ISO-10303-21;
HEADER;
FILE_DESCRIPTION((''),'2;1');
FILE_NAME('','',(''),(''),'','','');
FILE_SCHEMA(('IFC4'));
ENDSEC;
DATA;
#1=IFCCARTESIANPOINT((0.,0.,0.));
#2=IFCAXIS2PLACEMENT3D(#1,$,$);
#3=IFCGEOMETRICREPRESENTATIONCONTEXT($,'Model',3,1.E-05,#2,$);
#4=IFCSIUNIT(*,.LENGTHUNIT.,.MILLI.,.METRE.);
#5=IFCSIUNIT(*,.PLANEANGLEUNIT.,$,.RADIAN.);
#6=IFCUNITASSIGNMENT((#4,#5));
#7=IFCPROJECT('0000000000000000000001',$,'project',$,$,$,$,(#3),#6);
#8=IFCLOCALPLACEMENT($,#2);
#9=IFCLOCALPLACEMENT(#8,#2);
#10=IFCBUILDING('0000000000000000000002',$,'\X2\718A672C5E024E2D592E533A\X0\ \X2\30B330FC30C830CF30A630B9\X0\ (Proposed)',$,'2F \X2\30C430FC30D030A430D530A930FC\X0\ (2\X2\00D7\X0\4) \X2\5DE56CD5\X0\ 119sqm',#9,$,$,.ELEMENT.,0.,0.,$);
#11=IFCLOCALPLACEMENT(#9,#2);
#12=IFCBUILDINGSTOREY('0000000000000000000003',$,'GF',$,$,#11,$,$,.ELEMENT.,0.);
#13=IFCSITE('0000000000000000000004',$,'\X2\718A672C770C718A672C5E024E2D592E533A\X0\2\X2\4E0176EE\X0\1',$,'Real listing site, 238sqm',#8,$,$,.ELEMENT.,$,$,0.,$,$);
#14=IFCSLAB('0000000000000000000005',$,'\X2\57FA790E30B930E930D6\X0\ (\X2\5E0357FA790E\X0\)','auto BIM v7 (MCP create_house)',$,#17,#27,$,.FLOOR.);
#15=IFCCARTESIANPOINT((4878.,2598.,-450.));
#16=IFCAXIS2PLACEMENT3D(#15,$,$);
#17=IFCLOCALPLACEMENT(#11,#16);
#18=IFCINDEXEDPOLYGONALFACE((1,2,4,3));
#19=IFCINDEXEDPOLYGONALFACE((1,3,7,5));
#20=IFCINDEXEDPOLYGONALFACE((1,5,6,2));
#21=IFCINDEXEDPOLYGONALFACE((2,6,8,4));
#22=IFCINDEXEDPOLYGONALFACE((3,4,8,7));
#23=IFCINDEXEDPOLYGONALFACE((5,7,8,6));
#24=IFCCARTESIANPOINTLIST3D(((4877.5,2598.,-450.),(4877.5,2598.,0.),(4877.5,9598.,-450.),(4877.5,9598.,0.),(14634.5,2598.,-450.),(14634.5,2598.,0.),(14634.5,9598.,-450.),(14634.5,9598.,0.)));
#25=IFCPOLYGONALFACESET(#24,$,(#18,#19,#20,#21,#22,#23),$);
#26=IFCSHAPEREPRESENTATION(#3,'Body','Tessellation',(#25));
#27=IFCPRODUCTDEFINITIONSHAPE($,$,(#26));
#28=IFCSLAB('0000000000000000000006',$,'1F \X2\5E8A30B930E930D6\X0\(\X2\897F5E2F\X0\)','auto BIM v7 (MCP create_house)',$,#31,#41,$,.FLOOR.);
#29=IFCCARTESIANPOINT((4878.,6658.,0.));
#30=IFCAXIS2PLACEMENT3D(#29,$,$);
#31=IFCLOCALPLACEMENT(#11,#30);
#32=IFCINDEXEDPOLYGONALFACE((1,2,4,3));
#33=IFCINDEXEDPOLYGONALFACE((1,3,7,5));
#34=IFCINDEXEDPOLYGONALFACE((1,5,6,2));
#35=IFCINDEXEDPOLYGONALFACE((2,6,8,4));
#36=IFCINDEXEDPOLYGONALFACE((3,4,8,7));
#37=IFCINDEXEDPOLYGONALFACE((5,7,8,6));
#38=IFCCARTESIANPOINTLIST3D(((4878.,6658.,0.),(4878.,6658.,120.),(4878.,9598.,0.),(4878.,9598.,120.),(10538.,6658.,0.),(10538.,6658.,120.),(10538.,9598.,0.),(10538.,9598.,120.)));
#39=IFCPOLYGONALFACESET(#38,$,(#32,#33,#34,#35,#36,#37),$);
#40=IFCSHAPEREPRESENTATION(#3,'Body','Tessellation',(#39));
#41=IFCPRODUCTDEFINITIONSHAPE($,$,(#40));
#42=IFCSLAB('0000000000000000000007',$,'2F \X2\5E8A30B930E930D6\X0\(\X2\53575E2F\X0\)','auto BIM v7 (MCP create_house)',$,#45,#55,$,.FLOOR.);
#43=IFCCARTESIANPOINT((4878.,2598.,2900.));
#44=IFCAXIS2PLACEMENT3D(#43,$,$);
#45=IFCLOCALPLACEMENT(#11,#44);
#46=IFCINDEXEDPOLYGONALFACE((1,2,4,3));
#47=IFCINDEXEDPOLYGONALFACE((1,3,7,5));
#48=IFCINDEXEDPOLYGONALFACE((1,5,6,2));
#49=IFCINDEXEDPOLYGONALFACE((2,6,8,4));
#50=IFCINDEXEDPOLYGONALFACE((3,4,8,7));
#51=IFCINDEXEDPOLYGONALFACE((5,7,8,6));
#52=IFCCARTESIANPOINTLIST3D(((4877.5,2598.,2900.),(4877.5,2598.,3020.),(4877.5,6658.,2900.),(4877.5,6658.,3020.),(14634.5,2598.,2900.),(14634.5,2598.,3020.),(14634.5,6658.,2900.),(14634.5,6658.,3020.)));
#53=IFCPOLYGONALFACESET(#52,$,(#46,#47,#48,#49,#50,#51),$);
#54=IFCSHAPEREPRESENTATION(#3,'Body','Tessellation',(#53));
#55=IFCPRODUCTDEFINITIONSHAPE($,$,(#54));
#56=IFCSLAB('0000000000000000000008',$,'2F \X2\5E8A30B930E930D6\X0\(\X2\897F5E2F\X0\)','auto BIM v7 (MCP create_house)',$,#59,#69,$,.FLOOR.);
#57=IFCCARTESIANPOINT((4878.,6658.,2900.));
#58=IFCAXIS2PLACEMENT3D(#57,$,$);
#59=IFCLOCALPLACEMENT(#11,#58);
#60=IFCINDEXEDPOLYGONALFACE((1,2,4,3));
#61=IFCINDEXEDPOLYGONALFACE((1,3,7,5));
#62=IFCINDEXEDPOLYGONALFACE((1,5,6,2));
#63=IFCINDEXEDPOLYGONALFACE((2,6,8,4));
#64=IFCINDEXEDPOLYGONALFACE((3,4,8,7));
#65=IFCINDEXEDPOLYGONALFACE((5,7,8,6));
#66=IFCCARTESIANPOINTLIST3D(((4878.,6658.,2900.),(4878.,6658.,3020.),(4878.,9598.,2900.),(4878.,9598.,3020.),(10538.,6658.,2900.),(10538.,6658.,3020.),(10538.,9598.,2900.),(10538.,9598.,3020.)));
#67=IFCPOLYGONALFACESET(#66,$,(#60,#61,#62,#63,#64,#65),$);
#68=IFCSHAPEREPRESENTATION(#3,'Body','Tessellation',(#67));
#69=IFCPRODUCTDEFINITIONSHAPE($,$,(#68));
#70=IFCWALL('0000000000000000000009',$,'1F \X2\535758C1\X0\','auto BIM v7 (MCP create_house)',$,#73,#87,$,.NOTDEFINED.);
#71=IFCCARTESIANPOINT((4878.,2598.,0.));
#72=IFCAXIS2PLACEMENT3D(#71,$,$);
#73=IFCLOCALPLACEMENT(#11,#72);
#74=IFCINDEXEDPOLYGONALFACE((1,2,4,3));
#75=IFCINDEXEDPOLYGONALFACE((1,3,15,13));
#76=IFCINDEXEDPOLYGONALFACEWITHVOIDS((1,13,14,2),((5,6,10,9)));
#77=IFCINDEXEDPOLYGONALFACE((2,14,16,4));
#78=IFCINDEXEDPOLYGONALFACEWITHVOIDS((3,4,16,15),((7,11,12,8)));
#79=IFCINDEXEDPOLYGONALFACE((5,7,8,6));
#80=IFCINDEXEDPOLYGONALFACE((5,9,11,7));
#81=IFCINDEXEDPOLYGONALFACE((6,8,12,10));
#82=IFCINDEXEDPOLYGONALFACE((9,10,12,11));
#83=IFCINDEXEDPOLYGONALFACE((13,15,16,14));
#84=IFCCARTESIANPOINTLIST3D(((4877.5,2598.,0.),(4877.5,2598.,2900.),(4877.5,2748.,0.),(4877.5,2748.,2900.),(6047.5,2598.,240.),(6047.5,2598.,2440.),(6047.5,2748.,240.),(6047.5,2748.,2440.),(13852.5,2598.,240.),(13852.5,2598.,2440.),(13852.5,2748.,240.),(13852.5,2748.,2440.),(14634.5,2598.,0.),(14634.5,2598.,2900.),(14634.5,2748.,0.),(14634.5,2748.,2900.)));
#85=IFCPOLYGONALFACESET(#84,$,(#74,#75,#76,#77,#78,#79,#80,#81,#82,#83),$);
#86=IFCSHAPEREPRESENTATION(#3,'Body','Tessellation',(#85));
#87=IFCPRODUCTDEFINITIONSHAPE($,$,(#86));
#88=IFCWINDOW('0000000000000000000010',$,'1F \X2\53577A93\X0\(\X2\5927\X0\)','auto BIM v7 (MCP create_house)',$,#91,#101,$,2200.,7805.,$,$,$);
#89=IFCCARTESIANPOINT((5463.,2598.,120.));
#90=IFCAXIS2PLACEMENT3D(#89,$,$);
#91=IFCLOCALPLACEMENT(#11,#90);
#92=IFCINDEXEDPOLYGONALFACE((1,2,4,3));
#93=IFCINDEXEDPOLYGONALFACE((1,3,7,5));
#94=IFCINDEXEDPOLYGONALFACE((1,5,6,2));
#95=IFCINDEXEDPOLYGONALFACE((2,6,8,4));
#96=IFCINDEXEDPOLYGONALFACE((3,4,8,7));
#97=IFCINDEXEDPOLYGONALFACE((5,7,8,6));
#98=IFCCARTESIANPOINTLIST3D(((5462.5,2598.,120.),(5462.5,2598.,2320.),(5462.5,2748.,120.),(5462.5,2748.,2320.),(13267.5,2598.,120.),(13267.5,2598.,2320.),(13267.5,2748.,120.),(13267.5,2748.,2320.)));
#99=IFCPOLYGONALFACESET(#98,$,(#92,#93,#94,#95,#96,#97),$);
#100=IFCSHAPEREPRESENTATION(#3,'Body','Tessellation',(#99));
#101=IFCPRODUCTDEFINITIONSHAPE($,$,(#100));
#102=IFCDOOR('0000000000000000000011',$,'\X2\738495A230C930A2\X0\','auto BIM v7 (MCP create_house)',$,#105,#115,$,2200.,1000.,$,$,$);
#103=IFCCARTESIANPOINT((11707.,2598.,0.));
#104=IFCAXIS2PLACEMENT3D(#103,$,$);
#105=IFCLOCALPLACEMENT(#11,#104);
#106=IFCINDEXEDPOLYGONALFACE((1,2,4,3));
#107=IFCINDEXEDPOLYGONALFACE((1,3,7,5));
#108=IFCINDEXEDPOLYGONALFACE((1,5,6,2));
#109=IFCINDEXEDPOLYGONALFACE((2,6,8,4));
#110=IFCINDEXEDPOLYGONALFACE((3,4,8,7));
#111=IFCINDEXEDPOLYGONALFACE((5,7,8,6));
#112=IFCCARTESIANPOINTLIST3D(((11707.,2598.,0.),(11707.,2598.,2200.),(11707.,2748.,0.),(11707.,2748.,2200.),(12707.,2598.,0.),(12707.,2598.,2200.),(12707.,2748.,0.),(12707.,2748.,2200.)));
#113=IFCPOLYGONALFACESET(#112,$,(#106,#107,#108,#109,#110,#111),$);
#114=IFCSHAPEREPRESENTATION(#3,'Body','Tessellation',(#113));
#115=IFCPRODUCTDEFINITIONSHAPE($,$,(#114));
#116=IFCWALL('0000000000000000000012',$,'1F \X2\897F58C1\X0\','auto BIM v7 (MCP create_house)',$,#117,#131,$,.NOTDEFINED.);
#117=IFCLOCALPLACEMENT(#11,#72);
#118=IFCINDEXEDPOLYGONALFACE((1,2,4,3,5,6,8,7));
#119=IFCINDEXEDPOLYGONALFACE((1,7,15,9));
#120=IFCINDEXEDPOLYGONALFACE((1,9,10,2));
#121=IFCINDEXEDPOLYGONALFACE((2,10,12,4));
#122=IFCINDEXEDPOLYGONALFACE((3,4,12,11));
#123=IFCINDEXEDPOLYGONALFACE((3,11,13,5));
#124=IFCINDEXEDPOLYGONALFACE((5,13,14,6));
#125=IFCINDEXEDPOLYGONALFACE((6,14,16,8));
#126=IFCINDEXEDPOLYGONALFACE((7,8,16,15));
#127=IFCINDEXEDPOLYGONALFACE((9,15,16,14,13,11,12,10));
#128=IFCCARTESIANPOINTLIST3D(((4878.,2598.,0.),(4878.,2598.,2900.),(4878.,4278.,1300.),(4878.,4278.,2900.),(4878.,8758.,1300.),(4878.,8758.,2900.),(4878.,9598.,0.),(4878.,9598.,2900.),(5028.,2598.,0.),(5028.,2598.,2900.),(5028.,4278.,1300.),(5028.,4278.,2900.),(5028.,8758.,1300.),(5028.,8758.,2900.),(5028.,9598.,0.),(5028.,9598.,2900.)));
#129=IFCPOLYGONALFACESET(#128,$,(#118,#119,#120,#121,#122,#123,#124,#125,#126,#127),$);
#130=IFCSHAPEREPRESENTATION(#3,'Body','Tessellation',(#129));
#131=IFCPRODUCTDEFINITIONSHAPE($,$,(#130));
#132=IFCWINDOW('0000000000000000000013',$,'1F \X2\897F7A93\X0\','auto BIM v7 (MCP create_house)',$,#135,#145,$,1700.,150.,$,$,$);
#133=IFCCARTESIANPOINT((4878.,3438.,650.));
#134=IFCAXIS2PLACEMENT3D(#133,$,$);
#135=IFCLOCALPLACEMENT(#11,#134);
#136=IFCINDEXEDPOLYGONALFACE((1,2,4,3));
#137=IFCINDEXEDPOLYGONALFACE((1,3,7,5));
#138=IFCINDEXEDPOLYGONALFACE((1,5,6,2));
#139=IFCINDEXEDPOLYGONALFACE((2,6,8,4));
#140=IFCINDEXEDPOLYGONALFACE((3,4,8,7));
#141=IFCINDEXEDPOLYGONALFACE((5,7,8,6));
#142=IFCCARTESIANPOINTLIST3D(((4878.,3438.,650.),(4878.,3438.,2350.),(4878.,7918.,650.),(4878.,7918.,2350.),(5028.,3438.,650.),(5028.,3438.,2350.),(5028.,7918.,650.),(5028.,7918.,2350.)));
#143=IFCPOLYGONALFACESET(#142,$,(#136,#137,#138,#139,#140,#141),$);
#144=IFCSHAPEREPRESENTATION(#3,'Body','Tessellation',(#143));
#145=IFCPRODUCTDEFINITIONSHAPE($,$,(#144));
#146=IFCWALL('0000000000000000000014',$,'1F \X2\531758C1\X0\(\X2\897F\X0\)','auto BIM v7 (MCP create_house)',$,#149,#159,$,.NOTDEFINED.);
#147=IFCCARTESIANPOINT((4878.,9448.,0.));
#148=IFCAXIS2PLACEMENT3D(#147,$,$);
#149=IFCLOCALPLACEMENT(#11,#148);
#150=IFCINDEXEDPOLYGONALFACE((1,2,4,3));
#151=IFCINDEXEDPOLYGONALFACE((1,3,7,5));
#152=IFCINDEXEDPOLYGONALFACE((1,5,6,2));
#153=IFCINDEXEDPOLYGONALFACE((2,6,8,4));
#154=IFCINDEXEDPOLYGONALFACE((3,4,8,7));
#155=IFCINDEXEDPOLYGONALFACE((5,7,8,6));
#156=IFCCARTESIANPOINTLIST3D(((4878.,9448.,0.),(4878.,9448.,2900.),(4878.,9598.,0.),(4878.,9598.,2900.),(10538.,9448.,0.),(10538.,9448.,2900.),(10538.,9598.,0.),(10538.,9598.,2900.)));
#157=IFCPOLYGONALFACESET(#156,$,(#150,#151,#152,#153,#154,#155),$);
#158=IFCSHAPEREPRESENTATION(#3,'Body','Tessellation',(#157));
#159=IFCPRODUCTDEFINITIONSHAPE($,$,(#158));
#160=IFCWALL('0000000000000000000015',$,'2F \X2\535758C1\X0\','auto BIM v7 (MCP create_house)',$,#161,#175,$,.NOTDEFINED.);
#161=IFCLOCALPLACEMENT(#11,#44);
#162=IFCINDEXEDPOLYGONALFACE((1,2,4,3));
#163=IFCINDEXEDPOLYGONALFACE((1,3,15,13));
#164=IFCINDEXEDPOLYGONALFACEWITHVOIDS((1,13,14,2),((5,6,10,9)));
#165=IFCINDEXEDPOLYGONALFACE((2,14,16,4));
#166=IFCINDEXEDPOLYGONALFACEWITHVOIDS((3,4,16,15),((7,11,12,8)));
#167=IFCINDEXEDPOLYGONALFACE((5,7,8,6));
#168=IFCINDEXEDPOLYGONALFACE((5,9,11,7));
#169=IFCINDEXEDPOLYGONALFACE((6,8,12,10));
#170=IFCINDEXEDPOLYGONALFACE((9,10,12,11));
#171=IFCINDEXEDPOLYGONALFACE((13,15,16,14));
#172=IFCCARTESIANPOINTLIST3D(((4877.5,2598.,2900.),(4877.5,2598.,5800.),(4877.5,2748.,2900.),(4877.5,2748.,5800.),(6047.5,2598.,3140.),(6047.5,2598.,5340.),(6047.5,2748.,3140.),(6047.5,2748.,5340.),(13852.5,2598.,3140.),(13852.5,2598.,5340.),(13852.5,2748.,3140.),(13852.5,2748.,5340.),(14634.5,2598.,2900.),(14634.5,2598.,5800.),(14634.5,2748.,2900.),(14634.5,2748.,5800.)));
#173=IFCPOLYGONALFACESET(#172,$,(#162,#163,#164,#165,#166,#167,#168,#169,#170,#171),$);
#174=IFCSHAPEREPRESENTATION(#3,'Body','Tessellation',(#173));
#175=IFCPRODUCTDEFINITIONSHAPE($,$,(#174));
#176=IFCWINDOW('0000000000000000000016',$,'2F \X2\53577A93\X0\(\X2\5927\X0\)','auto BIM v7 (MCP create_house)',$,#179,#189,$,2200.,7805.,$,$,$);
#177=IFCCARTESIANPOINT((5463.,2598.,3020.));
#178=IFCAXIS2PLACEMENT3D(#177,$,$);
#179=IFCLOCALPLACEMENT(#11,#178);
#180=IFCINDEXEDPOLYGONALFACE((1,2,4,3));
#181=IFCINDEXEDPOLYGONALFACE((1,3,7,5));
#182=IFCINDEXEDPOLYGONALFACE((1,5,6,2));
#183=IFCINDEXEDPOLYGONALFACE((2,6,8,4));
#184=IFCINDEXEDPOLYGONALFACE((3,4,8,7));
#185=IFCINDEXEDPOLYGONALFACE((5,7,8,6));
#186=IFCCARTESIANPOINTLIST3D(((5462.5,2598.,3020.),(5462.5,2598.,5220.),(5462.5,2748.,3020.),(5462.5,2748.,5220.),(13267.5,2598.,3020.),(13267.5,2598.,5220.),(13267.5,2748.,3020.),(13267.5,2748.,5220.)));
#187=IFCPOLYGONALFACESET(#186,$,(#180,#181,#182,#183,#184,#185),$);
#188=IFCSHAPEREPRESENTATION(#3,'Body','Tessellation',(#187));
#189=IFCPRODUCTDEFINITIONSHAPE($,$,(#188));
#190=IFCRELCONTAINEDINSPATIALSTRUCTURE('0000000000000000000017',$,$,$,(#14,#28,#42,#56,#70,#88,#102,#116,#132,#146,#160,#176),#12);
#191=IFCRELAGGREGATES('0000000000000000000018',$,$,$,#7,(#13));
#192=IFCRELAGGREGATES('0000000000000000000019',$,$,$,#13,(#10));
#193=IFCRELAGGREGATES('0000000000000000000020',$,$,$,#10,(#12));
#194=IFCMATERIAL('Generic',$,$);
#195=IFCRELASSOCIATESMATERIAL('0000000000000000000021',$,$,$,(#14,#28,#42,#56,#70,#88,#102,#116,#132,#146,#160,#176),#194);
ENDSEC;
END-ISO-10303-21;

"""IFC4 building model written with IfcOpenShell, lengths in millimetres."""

from ifc_helpers import new_model, si_unit, frame, frame_2d, origin, place, context, project, spatial, rectangle, extrude, material, element, fill, save


model = new_model("IFC4")

# Units and contexts
model_context = context("Model", 3, precision=1e-05, world=origin())
ifc_project = project(units=[si_unit("LENGTHUNIT", "METRE", prefix="MILLI"), si_unit("PLANEANGLEUNIT", "RADIAN")], contexts=[model_context])

# Site, building, storey
site_placement = place(None, origin())
site = spatial("IfcSite", under=ifc_project, at=site_placement, Name="熊本県熊本市中央区2丁目1", ObjectType="Real listing site, 238sqm", CompositionType="ELEMENT", RefElevation=0.0)
building_placement = place(site_placement, origin())
building = spatial("IfcBuilding", under=site, at=building_placement, Name="熊本市中央区 コートハウス (Proposed)", ObjectType="2F ツーバイフォー (2×4) 工法 119sqm", CompositionType="ELEMENT", ElevationOfRefHeight=0.0, ElevationOfTerrain=0.0)
storey_placement = place(building_placement, origin())
storey = spatial("IfcBuildingStorey", under=building, at=storey_placement, Name="GF", CompositionType="ELEMENT", Elevation=0.0)

# Slabs
ifc_material = material(Name="Generic")
slab_1_placement = place(storey_placement, frame((4878.0, 2598.0, -450.0)))
element("IfcSlab", 1, at=slab_1_placement, inside=storey, material=ifc_material, Name="基礎スラブ (布基礎)", Description="auto BIM v7 (MCP create_house)", PredefinedType="FLOOR", context=model_context, shape_type="SweptSolid", body=[
    extrude(rectangle(XDim=9757.0, YDim=7000.0, at=frame_2d((4878.0, 3500.0))), frame((4878.0, 2598.0, -450.0)), (0.0, 0.0, 1.0), 450.0),
])
slab_2_placement = place(storey_placement, frame((4878.0, 6658.0, 0.0)))
element("IfcSlab", 2, at=slab_2_placement, inside=storey, material=ifc_material, Name="1F 床スラブ(西帯)", Description="auto BIM v7 (MCP create_house)", PredefinedType="FLOOR", context=model_context, shape_type="SweptSolid", body=[
    extrude(rectangle(XDim=5660.0, YDim=2940.0, at=frame_2d((2830.0, 1470.0))), frame((4878.0, 6658.0, 0.0)), (0.0, 0.0, 1.0), 120.0),
])
slab_3_placement = place(storey_placement, frame((4878.0, 2598.0, 2900.0)))
element("IfcSlab", 3, at=slab_3_placement, inside=storey, material=ifc_material, Name="2F 床スラブ(南帯)", Description="auto BIM v7 (MCP create_house)", PredefinedType="FLOOR", context=model_context, shape_type="SweptSolid", body=[
    extrude(rectangle(XDim=9757.0, YDim=4060.0, at=frame_2d((4878.0, 2030.0))), frame((4878.0, 2598.0, 2900.0)), (0.0, 0.0, 1.0), 120.0),
])
slab_4_placement = place(storey_placement, frame((4878.0, 6658.0, 2900.0)))
element("IfcSlab", 4, at=slab_4_placement, inside=storey, material=ifc_material, Name="2F 床スラブ(西帯)", Description="auto BIM v7 (MCP create_house)", PredefinedType="FLOOR", context=model_context, shape_type="SweptSolid", body=[
    extrude(rectangle(XDim=5660.0, YDim=2940.0, at=frame_2d((2830.0, 1470.0))), frame((4878.0, 6658.0, 2900.0)), (0.0, 0.0, 1.0), 120.0),
])

# Wall, openings, window, door
wall_1_placement = place(storey_placement, frame((4878.0, 2598.0, 0.0)))
wall_1 = element("IfcWall", 5, at=wall_1_placement, inside=storey, material=ifc_material, Name="1F 南壁", Description="auto BIM v7 (MCP create_house)", PredefinedType="NOTDEFINED", context=model_context, shape_type="SweptSolid", body=[
    extrude(rectangle(XDim=9757.0, YDim=150.0, at=frame_2d((4878.0, 75.0))), frame((4878.0, 2598.0, 0.0)), (0.0, 0.0, 1.0), 2900.0),
])
opening_1_placement = place(storey_placement, frame((5463.0, 2598.0, 120.0)))
opening_1 = element("IfcOpeningElement", 6, at=opening_1_placement, cuts=wall_1, PredefinedType="NOTDEFINED", context=model_context, shape_type="SweptSolid", body=[
    extrude(rectangle(XDim=7805.0, YDim=150.0, at=frame_2d((3902.0, 75.0))), frame((5463.0, 2598.0, 120.0)), (0.0, 0.0, 1.0), 2200.0),
])
opening_2_placement = place(storey_placement, frame((11707.0, 2598.0, 0.0)))
opening_2 = element("IfcOpeningElement", 7, at=opening_2_placement, cuts=wall_1, PredefinedType="NOTDEFINED", context=model_context, shape_type="SweptSolid", body=[
    extrude(rectangle(XDim=1000.0, YDim=150.0, at=frame_2d((500.0, 75.0))), frame((11707.0, 2598.0, 0.0)), (0.0, 0.0, 1.0), 2200.0),
])
window_1_placement = place(storey_placement, frame((5463.0, 2598.0, 120.0)))
window_1 = element("IfcWindow", 8, at=window_1_placement, inside=storey, material=ifc_material, Name="1F 南窓(大)", Description="auto BIM v7 (MCP create_house)", OverallHeight=2200.0, OverallWidth=7805.0, context=model_context, shape_type="SweptSolid", body=[
    extrude(rectangle(XDim=7805.0, YDim=150.0, at=frame_2d((3902.0, 75.0))), frame((5463.0, 2598.0, 120.0)), (0.0, 0.0, 1.0), 2200.0),
])
fill(opening_1, window_1)
door_placement = place(storey_placement, frame((11707.0, 2598.0, 0.0)))
door = element("IfcDoor", 9, at=door_placement, inside=storey, material=ifc_material, Name="玄関ドア", Description="auto BIM v7 (MCP create_house)", OverallHeight=2200.0, OverallWidth=1000.0, context=model_context, shape_type="SweptSolid", body=[
    extrude(rectangle(XDim=1000.0, YDim=150.0, at=frame_2d((500.0, 75.0))), frame((11707.0, 2598.0, 0.0)), (0.0, 0.0, 1.0), 2200.0),
])
fill(opening_2, door)

# Wall, opening, window
wall_2_placement = place(storey_placement, frame((4878.0, 2598.0, 0.0)))
wall_2 = element("IfcWall", 10, at=wall_2_placement, inside=storey, material=ifc_material, Name="1F 西壁", Description="auto BIM v7 (MCP create_house)", PredefinedType="NOTDEFINED", context=model_context, shape_type="SweptSolid", body=[
    extrude(rectangle(XDim=150.0, YDim=7000.0, at=frame_2d((75.0, 3500.0))), frame((4878.0, 2598.0, 0.0)), (0.0, 0.0, 1.0), 2900.0),
])
opening_3_placement = place(storey_placement, frame((4878.0, 3438.0, 650.0)))
opening_3 = element("IfcOpeningElement", 11, at=opening_3_placement, cuts=wall_2, PredefinedType="NOTDEFINED", context=model_context, shape_type="SweptSolid", body=[
    extrude(rectangle(XDim=150.0, YDim=4480.0, at=frame_2d((75.0, 2240.0))), frame((4878.0, 3438.0, 650.0)), (0.0, 0.0, 1.0), 1700.0),
])
window_2_placement = place(storey_placement, frame((4878.0, 3438.0, 650.0)))
window_2 = element("IfcWindow", 12, at=window_2_placement, inside=storey, material=ifc_material, Name="1F 西窓", Description="auto BIM v7 (MCP create_house)", OverallHeight=1700.0, OverallWidth=150.0, context=model_context, shape_type="SweptSolid", body=[
    extrude(rectangle(XDim=150.0, YDim=4480.0, at=frame_2d((75.0, 2240.0))), frame((4878.0, 3438.0, 650.0)), (0.0, 0.0, 1.0), 1700.0),
])
fill(opening_3, window_2)

# Wall
wall_3_placement = place(storey_placement, frame((4878.0, 9448.0, 0.0)))
element("IfcWall", 13, at=wall_3_placement, inside=storey, material=ifc_material, Name="1F 北壁(西)", Description="auto BIM v7 (MCP create_house)", PredefinedType="NOTDEFINED", context=model_context, shape_type="SweptSolid", body=[
    extrude(rectangle(XDim=5660.0, YDim=150.0, at=frame_2d((2830.0, 75.0))), frame((4878.0, 9448.0, 0.0)), (0.0, 0.0, 1.0), 2900.0),
])

# Wall, opening, window
wall_4_placement = place(storey_placement, frame((4878.0, 2598.0, 2900.0)))
wall_4 = element("IfcWall", 14, at=wall_4_placement, inside=storey, material=ifc_material, Name="2F 南壁", Description="auto BIM v7 (MCP create_house)", PredefinedType="NOTDEFINED", context=model_context, shape_type="SweptSolid", body=[
    extrude(rectangle(XDim=9757.0, YDim=150.0, at=frame_2d((4878.0, 75.0))), frame((4878.0, 2598.0, 2900.0)), (0.0, 0.0, 1.0), 2900.0),
])
opening_4_placement = place(storey_placement, frame((5463.0, 2598.0, 3020.0)))
opening_4 = element("IfcOpeningElement", 15, at=opening_4_placement, cuts=wall_4, PredefinedType="NOTDEFINED", context=model_context, shape_type="SweptSolid", body=[
    extrude(rectangle(XDim=7805.0, YDim=150.0, at=frame_2d((3902.0, 75.0))), frame((5463.0, 2598.0, 3020.0)), (0.0, 0.0, 1.0), 2200.0),
])
window_3_placement = place(storey_placement, frame((5463.0, 2598.0, 3020.0)))
window_3 = element("IfcWindow", 16, at=window_3_placement, inside=storey, material=ifc_material, Name="2F 南窓(大)", Description="auto BIM v7 (MCP create_house)", OverallHeight=2200.0, OverallWidth=7805.0, context=model_context, shape_type="SweptSolid", body=[
    extrude(rectangle(XDim=7805.0, YDim=150.0, at=frame_2d((3902.0, 75.0))), frame((5463.0, 2598.0, 3020.0)), (0.0, 0.0, 1.0), 2200.0),
])
fill(opening_4, window_3)

save(model, "model.ifc")
